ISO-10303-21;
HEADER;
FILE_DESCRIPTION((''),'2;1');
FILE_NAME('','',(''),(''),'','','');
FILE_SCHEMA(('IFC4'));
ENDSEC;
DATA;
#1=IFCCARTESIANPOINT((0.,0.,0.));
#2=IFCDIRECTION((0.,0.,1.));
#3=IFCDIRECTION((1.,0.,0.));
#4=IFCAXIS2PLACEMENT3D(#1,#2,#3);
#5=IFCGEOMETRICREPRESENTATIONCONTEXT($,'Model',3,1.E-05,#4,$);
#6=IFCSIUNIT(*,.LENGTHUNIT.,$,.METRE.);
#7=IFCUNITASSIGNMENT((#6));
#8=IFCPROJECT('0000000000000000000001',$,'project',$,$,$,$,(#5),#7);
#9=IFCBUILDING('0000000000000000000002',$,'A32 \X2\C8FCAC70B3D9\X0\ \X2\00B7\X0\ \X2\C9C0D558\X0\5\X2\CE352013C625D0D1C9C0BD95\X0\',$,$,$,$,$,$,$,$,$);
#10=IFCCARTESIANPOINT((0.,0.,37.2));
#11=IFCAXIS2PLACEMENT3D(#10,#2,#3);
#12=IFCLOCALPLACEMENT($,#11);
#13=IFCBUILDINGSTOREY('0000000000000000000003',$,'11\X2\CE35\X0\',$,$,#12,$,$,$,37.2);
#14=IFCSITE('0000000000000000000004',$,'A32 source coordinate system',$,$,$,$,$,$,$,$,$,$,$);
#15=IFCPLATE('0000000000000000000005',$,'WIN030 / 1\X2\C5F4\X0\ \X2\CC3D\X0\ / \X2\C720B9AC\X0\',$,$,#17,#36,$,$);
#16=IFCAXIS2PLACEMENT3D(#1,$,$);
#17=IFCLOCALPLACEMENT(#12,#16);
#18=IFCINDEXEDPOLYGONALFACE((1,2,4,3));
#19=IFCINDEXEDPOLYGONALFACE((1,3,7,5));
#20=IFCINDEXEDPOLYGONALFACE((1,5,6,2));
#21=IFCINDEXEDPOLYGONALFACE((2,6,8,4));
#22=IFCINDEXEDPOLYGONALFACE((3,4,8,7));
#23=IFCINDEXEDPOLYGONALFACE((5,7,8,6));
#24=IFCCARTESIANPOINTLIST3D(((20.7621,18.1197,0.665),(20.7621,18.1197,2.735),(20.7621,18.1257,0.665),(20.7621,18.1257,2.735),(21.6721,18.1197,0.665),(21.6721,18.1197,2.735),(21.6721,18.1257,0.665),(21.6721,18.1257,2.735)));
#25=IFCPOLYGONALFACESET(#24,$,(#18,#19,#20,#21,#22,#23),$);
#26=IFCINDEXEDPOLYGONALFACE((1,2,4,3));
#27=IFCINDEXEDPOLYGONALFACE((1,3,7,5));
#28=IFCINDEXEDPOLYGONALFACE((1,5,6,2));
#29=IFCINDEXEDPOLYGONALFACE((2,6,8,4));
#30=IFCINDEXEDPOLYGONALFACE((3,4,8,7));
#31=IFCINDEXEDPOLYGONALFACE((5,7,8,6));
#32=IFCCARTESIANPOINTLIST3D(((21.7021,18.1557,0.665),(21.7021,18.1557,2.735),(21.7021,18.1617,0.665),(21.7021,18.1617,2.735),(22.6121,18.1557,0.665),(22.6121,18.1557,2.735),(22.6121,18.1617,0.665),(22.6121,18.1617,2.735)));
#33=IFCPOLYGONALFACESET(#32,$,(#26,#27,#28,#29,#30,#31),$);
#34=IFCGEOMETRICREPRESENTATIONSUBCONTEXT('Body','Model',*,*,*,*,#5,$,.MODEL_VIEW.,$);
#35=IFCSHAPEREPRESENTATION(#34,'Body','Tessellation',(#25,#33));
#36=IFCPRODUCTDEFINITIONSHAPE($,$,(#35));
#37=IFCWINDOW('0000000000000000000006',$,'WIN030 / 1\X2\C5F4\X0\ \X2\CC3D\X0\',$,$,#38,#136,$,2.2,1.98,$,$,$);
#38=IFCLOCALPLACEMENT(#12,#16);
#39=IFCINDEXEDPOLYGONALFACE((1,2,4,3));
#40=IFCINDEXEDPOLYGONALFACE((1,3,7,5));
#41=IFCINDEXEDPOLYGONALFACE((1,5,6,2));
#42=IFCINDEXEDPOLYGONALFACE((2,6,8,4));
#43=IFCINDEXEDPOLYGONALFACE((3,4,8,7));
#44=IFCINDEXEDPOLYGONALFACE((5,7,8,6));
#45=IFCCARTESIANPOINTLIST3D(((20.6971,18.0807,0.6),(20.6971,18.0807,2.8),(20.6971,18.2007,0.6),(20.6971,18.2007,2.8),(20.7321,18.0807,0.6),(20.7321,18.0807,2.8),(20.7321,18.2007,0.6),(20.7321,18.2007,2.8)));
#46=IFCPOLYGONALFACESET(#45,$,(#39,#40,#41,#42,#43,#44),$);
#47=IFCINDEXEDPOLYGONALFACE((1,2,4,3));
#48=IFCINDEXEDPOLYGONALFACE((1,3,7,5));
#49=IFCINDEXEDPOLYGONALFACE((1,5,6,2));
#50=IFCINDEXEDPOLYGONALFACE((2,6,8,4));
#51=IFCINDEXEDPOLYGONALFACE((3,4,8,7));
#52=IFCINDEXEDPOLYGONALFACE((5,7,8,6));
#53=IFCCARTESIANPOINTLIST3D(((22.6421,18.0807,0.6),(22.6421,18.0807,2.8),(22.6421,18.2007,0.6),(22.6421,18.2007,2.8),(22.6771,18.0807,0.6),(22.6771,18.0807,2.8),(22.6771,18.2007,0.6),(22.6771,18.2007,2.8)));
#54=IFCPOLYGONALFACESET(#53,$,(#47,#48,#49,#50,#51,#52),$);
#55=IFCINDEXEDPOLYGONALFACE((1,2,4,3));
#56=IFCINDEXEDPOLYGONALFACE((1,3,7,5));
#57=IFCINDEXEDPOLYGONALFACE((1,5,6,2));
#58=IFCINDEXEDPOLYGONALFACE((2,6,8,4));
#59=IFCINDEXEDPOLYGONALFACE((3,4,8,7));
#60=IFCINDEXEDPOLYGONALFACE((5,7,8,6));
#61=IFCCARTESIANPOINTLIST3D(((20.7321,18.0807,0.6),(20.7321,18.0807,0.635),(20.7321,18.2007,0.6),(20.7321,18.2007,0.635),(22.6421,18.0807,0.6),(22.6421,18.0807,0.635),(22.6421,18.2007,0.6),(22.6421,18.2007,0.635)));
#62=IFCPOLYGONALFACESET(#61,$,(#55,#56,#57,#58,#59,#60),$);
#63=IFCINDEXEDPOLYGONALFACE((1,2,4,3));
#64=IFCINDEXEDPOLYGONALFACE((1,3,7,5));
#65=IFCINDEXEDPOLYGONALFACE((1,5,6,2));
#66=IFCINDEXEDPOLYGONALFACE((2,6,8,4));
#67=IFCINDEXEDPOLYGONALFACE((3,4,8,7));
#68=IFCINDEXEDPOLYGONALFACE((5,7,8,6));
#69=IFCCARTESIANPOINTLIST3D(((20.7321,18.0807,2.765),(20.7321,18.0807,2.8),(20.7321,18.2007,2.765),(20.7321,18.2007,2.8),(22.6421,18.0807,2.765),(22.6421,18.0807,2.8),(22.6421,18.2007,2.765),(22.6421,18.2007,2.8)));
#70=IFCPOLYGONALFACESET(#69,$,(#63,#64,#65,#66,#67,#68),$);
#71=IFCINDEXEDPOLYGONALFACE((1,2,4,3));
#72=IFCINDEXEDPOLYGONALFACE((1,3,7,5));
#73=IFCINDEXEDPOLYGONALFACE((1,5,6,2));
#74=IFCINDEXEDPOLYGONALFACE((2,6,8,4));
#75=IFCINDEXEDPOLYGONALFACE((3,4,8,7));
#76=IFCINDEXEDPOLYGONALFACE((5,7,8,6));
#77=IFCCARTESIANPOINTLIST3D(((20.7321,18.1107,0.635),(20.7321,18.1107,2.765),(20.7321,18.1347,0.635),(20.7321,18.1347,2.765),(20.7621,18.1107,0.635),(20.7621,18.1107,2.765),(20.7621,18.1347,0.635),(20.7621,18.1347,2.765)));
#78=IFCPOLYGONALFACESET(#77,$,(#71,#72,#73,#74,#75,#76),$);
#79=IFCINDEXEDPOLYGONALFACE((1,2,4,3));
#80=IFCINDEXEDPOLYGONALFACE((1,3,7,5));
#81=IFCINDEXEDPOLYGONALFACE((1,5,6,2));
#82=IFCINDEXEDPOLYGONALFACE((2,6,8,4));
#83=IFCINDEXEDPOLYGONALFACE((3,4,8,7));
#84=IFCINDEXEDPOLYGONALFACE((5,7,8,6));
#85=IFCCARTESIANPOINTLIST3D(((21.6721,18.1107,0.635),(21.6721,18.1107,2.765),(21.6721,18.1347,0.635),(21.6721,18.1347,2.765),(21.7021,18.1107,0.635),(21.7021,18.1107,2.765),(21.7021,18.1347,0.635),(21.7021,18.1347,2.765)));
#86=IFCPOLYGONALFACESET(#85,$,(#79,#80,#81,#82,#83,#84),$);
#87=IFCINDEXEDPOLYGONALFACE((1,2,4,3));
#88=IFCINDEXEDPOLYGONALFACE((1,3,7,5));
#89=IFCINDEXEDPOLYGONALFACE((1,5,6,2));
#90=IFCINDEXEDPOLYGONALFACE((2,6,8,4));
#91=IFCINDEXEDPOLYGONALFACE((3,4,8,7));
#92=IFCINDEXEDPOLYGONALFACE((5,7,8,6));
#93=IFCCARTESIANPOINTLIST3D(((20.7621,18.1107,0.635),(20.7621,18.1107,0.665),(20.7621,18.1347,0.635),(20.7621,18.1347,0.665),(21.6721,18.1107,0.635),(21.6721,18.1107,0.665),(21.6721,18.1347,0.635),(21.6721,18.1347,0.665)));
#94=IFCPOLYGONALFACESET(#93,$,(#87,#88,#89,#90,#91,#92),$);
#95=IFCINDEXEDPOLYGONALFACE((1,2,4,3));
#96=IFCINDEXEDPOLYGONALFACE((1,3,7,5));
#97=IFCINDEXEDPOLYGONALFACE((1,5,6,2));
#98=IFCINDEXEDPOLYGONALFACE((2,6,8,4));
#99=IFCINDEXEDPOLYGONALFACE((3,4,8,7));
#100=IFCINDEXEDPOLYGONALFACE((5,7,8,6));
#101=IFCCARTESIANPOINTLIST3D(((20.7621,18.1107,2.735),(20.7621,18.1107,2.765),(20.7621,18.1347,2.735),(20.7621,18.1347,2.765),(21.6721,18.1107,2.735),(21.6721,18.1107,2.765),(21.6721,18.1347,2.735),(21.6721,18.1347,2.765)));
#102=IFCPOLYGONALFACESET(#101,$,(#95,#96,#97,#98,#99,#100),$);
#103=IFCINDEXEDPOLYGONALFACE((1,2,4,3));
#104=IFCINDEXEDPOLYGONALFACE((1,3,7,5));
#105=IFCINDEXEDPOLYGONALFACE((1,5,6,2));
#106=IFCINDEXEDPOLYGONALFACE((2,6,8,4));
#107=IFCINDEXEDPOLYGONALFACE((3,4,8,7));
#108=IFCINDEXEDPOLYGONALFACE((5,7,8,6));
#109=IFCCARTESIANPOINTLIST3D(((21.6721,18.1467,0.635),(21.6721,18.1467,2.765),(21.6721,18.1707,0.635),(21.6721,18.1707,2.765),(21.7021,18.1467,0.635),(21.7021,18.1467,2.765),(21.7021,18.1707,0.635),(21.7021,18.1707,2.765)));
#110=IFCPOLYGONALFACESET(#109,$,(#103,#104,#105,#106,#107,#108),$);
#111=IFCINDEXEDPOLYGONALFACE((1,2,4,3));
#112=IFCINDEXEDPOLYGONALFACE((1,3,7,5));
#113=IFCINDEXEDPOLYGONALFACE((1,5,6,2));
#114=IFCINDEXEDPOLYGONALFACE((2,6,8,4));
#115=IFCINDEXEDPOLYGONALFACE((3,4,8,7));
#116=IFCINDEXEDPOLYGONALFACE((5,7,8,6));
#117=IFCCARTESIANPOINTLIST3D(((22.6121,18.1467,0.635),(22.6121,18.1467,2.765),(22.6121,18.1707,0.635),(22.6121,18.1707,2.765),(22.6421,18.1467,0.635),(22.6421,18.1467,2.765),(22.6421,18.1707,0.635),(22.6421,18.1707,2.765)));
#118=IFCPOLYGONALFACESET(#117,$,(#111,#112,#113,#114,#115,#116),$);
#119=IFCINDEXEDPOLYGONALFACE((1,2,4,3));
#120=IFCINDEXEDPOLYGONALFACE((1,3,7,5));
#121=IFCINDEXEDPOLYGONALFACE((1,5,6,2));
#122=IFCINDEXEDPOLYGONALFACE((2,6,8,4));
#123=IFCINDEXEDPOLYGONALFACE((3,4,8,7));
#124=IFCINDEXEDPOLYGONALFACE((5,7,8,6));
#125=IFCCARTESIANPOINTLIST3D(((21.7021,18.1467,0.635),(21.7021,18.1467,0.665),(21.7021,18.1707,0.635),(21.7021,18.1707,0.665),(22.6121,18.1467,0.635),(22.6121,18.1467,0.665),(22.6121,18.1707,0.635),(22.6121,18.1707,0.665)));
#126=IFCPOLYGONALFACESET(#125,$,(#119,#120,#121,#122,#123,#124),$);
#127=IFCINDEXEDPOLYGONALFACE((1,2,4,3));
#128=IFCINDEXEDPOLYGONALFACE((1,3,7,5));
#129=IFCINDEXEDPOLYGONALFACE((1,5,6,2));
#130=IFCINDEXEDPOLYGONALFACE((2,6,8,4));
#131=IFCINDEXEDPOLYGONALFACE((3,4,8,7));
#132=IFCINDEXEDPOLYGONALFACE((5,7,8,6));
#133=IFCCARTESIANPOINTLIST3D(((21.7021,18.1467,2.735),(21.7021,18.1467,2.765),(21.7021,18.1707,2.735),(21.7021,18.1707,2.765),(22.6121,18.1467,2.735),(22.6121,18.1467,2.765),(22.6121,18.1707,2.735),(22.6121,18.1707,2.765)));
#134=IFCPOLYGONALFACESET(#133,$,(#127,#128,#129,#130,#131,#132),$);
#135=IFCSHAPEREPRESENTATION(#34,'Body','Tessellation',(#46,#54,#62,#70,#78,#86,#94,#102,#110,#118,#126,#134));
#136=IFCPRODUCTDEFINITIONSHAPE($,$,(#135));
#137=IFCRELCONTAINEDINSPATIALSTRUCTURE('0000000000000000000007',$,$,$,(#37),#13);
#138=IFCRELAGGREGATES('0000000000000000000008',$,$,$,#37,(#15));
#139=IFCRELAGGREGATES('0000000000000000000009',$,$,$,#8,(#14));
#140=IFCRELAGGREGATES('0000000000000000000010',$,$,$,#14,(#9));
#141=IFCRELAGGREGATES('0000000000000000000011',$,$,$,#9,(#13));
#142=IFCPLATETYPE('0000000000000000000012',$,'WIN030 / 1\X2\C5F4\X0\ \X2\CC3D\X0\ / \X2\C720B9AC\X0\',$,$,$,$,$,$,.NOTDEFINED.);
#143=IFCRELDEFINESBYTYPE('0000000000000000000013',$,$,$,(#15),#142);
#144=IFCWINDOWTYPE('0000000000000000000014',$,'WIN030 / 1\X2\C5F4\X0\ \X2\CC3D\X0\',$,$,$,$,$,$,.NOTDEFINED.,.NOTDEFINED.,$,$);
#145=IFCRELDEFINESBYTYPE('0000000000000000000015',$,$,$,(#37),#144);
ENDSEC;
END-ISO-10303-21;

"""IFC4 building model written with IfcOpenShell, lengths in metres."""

from ifc_helpers import new_model, si_unit, frame, origin, origin_with_axes, place, context, subcontext, project, spatial, polyline, outline, extrude, source, transform, mapped, type_object, type_shapes, element, aggregate, save


model = new_model("IFC4")

# Units and contexts
model_context = context("Model", 3, precision=1e-05, world=origin_with_axes())
body_context = subcontext(model_context, "Body", "Model", "MODEL_VIEW")
ifc_project = project(units=[si_unit("LENGTHUNIT", "METRE")], contexts=[model_context])

# Plate
storey_placement = place(None, frame((0.0, 0.0, 37.2), z_axis=(0.0, 0.0, 1.0), x_axis=(1.0, 0.0, 0.0)))
plate_type_1 = type_object("IfcPlateType", Name="WIN030 / 1열 창 / 유리", PredefinedType="NOTDEFINED")
shared_shape_1 = source(origin(), body_context, "Body", "SweptSolid", [
    extrude(outline(polyline([(20.7621, 18.1197), (20.7621, 18.1257), (21.6721, 18.1257), (21.6721, 18.1197), (20.7621, 18.1197)])), frame((0.0, 0.0, 0.665)), (0.0, 0.0, 1.0), 2.07),
    extrude(outline(polyline([(21.7021, 18.1557), (21.7021, 18.1617), (22.6121, 18.1617), (22.6121, 18.1557), (21.7021, 18.1557)])), frame((0.0, 0.0, 0.665)), (0.0, 0.0, 1.0), 2.07),
])
type_shapes(plate_type_1, [shared_shape_1])
window_1_placement = place(storey_placement, origin_with_axes())
plate_1_placement = place(window_1_placement, origin_with_axes())
plate_1 = element("IfcPlate", 1, at=plate_1_placement, type_object=plate_type_1, Name="WIN030 / 1열 창 / 유리", context=body_context, shape_type="MappedRepresentation", body=[
    mapped(shared_shape_1, transform((0.0, 0.0, 0.0), scale=1.0)),
])

# Site, building, storey
site = spatial("IfcSite", under=ifc_project, Name="A32 source coordinate system")
building = spatial("IfcBuilding", under=site, Name="A32 주거동 · 지하5층–옥탑지붕")
storey = spatial("IfcBuildingStorey", under=building, at=storey_placement, Name="11층", Elevation=37.2)

# Window
window_type_1 = type_object("IfcWindowType", Name="WIN030 / 1열 창", PartitioningType="NOTDEFINED", PredefinedType="NOTDEFINED")
shared_shape_2 = source(origin(), body_context, "Body", "SweptSolid", [
    extrude(outline(polyline([(20.6971, 18.0807), (20.6971, 18.2007), (20.7321, 18.2007), (20.7321, 18.0807), (20.6971, 18.0807)])), frame((0.0, 0.0, 0.6)), (0.0, 0.0, 1.0), 2.2),
    extrude(outline(polyline([(22.6421, 18.0807), (22.6421, 18.2007), (22.6771, 18.2007), (22.6771, 18.0807), (22.6421, 18.0807)])), frame((0.0, 0.0, 0.6)), (0.0, 0.0, 1.0), 2.2),
    extrude(outline(polyline([(20.7321, 18.0807), (20.7321, 18.2007), (22.6421, 18.2007), (22.6421, 18.0807), (20.7321, 18.0807)])), frame((0.0, 0.0, 0.6)), (0.0, 0.0, 1.0), 0.035),
    extrude(outline(polyline([(20.7321, 18.0807), (20.7321, 18.2007), (22.6421, 18.2007), (22.6421, 18.0807), (20.7321, 18.0807)])), frame((0.0, 0.0, 2.765)), (0.0, 0.0, 1.0), 0.035),
    extrude(outline(polyline([(20.7321, 18.1107), (20.7321, 18.1347), (20.7621, 18.1347), (20.7621, 18.1107), (20.7321, 18.1107)])), frame((0.0, 0.0, 0.635)), (0.0, 0.0, 1.0), 2.13),
    extrude(outline(polyline([(21.6721, 18.1107), (21.6721, 18.1347), (21.7021, 18.1347), (21.7021, 18.1107), (21.6721, 18.1107)])), frame((0.0, 0.0, 0.635)), (0.0, 0.0, 1.0), 2.13),
    extrude(outline(polyline([(20.7621, 18.1107), (20.7621, 18.1347), (21.6721, 18.1347), (21.6721, 18.1107), (20.7621, 18.1107)])), frame((0.0, 0.0, 0.635)), (0.0, 0.0, 1.0), 0.03),
    extrude(outline(polyline([(20.7621, 18.1107), (20.7621, 18.1347), (21.6721, 18.1347), (21.6721, 18.1107), (20.7621, 18.1107)])), frame((0.0, 0.0, 2.735)), (0.0, 0.0, 1.0), 0.03),
    extrude(outline(polyline([(21.6721, 18.1467), (21.6721, 18.1707), (21.7021, 18.1707), (21.7021, 18.1467), (21.6721, 18.1467)])), frame((0.0, 0.0, 0.635)), (0.0, 0.0, 1.0), 2.13),
    extrude(outline(polyline([(22.6121, 18.1467), (22.6121, 18.1707), (22.6421, 18.1707), (22.6421, 18.1467), (22.6121, 18.1467)])), frame((0.0, 0.0, 0.635)), (0.0, 0.0, 1.0), 2.13),
    extrude(outline(polyline([(21.7021, 18.1467), (21.7021, 18.1707), (22.6121, 18.1707), (22.6121, 18.1467), (21.7021, 18.1467)])), frame((0.0, 0.0, 0.635)), (0.0, 0.0, 1.0), 0.03),
    extrude(outline(polyline([(21.7021, 18.1467), (21.7021, 18.1707), (22.6121, 18.1707), (22.6121, 18.1467), (21.7021, 18.1467)])), frame((0.0, 0.0, 2.735)), (0.0, 0.0, 1.0), 0.03),
])
type_shapes(window_type_1, [shared_shape_2])
window_1 = element("IfcWindow", 2, at=window_1_placement, inside=storey, type_object=window_type_1, Name="WIN030 / 1열 창", OverallHeight=2.2, OverallWidth=1.98, context=body_context, shape_type="MappedRepresentation", body=[
    mapped(shared_shape_2, transform((0.0, 0.0, 0.0), scale=1.0)),
])
aggregate(window_1, [plate_1])

save(model, "model.ifc")
